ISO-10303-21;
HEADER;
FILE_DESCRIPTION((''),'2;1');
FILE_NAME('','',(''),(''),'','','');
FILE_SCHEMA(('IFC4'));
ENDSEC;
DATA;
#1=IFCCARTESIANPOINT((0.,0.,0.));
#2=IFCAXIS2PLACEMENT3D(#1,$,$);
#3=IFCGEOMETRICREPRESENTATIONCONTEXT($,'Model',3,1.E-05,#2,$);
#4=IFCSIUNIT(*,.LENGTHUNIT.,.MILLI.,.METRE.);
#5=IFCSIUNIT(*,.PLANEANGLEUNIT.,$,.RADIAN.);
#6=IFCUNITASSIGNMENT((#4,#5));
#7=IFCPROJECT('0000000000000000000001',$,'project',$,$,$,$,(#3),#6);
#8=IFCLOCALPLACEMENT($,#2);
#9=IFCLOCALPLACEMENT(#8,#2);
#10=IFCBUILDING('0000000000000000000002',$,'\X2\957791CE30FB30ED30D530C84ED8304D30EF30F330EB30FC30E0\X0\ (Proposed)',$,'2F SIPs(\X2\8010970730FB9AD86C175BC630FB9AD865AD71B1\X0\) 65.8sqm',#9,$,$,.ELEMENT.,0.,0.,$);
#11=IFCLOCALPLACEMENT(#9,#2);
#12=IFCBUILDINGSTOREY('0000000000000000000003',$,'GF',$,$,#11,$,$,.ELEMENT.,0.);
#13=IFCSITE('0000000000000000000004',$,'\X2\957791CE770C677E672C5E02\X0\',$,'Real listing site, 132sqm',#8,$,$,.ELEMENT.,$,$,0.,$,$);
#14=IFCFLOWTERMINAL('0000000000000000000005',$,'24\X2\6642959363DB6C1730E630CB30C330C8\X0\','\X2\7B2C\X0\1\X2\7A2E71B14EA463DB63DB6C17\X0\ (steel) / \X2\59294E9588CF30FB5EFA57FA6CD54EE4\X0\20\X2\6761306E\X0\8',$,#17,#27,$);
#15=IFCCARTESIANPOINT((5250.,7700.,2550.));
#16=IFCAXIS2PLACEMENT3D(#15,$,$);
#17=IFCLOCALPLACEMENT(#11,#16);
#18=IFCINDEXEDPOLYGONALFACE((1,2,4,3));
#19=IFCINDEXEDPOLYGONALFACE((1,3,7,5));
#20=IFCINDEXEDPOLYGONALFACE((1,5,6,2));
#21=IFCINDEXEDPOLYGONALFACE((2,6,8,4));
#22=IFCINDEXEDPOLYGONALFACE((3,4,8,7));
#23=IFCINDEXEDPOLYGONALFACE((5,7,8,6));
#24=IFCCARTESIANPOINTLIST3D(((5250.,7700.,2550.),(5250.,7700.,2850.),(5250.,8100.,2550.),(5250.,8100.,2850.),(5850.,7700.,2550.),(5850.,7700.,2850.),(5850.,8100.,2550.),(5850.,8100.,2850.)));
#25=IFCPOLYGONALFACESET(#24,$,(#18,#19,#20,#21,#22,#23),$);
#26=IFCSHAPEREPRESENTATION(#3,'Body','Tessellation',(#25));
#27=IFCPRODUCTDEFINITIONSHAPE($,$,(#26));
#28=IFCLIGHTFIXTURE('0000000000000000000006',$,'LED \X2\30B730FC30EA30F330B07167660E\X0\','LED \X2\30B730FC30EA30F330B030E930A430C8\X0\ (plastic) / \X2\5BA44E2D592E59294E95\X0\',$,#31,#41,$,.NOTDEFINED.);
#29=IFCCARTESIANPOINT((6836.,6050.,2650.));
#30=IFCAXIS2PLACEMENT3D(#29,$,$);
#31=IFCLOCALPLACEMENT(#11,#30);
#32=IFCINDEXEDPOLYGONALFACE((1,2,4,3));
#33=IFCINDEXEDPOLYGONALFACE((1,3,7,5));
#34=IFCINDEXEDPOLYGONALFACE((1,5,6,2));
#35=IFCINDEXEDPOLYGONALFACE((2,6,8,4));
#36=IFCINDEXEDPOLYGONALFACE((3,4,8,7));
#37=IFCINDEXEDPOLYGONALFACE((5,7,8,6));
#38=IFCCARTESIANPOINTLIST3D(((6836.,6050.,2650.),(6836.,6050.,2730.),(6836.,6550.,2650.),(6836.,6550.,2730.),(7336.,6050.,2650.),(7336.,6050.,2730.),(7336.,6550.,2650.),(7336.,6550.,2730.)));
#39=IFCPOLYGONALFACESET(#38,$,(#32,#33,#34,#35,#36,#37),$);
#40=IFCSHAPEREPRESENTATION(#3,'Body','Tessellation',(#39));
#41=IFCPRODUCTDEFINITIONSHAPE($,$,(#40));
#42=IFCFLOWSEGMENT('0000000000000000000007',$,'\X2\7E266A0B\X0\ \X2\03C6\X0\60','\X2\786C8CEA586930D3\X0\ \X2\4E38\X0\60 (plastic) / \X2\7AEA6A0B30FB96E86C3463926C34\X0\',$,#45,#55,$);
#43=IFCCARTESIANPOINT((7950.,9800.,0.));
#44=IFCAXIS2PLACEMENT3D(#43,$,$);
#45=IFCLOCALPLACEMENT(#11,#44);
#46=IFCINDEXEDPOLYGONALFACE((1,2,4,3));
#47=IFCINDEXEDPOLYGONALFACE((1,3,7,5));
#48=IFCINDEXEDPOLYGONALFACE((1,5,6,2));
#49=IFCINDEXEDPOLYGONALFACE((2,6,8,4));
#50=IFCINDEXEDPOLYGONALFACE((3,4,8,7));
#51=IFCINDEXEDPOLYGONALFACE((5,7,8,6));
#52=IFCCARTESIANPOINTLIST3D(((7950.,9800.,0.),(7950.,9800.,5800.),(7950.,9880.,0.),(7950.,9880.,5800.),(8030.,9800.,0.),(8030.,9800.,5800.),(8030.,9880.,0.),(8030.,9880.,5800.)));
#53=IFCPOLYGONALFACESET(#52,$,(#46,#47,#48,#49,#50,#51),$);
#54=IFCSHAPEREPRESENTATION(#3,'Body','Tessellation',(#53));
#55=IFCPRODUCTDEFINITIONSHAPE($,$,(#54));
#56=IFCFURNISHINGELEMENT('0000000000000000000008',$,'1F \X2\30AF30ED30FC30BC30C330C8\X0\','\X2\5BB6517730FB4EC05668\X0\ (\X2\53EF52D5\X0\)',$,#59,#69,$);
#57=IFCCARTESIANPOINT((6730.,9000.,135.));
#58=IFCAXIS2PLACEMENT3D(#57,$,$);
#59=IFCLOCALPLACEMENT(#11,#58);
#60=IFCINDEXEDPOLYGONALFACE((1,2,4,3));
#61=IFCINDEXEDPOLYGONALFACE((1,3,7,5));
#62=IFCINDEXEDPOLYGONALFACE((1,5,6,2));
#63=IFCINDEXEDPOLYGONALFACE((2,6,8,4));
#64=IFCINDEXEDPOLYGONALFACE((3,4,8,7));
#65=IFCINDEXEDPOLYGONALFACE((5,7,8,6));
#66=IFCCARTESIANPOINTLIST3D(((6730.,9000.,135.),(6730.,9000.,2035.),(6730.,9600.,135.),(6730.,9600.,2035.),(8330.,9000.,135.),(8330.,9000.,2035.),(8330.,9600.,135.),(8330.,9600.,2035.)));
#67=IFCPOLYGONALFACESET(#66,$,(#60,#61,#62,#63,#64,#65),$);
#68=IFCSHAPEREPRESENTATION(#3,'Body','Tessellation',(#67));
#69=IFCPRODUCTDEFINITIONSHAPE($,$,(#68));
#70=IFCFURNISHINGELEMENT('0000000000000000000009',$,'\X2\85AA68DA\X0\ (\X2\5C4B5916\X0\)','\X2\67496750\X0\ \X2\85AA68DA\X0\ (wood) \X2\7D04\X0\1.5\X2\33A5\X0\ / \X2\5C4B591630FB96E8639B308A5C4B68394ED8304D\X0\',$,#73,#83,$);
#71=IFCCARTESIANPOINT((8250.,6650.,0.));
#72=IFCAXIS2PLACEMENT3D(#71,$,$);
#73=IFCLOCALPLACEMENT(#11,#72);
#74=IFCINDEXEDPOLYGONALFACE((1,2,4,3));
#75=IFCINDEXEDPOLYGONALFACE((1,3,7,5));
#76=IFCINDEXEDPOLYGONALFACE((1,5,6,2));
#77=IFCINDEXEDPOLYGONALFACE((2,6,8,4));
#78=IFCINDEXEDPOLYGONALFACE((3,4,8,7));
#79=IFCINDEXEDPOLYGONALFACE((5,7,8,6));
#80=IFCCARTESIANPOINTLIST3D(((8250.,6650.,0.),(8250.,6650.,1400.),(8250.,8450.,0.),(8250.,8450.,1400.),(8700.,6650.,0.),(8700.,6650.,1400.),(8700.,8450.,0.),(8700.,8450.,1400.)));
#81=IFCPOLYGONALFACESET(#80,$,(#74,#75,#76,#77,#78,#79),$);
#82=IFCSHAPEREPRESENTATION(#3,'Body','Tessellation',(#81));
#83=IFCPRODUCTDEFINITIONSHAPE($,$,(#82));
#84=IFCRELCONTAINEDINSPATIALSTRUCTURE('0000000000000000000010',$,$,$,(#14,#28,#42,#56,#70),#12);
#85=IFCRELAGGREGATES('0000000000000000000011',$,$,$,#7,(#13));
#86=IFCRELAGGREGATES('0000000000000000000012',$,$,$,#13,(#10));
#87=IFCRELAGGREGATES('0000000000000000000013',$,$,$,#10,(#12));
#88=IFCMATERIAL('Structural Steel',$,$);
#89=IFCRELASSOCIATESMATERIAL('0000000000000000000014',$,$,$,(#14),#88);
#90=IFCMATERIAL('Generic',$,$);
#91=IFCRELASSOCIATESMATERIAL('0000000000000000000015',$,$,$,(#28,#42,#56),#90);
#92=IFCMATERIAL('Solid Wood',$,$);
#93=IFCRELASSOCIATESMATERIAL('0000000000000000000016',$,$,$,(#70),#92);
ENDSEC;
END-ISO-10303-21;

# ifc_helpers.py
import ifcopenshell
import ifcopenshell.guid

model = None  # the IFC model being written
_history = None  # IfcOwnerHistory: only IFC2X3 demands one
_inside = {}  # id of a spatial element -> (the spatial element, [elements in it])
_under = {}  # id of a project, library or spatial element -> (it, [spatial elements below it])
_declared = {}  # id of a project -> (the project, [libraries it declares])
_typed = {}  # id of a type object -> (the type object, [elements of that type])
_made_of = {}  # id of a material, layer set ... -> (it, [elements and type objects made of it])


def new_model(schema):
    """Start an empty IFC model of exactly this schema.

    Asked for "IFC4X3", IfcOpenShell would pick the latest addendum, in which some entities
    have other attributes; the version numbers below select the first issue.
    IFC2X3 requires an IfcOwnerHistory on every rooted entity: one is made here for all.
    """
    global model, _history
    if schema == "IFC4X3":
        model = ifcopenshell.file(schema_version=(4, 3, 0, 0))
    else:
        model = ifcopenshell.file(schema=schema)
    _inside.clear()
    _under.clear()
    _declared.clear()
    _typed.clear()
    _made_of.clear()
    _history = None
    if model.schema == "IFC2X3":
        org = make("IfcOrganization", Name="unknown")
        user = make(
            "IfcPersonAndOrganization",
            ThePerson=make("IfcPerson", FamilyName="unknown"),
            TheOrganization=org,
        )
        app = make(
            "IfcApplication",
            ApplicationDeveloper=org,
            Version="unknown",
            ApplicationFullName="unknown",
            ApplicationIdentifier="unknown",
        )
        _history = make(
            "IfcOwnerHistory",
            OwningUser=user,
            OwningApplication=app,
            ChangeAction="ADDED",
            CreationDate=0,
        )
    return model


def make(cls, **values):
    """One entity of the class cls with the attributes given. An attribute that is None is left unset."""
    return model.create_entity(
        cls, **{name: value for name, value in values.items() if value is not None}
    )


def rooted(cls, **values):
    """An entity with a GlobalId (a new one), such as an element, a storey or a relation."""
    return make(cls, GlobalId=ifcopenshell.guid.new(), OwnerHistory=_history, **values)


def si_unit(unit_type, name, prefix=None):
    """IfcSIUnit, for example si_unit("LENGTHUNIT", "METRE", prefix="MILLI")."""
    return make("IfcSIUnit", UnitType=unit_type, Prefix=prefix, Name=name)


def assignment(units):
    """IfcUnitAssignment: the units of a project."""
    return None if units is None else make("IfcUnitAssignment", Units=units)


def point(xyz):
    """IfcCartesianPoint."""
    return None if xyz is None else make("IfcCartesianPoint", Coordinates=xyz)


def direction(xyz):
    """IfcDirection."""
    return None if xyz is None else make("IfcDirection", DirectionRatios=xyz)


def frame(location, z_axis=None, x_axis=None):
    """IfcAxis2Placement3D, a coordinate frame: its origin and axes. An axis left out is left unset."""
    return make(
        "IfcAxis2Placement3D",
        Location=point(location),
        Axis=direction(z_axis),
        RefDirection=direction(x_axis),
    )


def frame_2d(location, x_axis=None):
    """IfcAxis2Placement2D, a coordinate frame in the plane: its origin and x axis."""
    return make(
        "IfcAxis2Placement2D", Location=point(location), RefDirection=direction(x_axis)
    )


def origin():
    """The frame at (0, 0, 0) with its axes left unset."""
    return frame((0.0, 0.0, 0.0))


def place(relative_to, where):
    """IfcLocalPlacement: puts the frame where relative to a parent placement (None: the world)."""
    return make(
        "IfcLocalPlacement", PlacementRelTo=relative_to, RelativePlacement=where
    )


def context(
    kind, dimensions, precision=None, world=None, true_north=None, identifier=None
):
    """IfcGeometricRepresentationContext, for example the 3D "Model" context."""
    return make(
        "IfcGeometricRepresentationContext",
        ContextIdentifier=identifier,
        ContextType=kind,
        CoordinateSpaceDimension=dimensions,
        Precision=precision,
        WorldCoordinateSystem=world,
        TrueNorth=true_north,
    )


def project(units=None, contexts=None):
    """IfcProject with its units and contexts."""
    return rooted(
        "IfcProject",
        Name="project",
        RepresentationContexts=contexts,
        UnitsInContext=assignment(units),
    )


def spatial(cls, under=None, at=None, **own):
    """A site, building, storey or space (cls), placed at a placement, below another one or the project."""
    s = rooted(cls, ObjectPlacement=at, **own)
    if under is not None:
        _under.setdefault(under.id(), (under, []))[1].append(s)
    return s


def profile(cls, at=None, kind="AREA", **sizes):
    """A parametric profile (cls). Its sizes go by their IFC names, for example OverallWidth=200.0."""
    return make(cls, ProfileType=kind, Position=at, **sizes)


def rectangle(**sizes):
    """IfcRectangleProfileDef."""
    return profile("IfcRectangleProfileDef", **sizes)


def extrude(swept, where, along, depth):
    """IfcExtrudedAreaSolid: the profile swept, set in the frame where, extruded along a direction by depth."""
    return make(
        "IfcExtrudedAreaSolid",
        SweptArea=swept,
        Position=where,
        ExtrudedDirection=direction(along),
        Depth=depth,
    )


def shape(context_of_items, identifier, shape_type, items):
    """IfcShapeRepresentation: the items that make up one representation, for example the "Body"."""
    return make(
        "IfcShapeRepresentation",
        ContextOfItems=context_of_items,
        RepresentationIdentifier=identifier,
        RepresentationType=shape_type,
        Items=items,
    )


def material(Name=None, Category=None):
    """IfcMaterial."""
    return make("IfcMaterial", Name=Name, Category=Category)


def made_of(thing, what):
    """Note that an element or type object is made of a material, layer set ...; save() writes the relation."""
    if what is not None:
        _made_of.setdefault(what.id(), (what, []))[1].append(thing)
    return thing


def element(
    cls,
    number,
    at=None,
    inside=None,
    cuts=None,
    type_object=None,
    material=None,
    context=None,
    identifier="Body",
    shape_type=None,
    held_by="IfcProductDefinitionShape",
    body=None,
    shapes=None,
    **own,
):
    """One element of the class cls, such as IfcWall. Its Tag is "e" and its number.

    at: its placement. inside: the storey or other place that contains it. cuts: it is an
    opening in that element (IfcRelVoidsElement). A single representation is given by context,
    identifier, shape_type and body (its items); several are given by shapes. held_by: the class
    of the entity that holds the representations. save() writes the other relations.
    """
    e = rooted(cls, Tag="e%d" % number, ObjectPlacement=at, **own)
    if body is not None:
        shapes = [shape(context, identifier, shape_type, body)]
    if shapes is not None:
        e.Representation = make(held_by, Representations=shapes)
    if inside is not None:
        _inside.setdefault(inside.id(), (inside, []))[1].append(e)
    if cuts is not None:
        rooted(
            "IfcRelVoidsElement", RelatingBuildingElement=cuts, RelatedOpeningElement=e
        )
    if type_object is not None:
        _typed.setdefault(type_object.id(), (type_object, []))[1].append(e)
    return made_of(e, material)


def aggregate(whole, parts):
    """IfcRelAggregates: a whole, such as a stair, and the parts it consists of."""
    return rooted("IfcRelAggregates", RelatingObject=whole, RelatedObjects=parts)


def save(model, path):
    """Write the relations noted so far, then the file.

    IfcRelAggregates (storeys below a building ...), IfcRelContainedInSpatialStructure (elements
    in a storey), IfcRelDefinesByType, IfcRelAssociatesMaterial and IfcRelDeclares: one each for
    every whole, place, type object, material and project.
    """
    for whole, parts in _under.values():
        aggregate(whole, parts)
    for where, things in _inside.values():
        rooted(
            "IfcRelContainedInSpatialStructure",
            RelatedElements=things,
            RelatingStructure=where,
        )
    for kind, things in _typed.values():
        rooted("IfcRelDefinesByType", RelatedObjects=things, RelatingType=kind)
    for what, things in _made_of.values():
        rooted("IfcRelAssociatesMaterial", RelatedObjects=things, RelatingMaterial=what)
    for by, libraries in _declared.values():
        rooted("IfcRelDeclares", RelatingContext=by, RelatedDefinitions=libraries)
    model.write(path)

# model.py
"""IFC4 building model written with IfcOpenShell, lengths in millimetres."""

from ifc_helpers import new_model, si_unit, frame, frame_2d, origin, place, context, project, spatial, rectangle, extrude, material, element, save


model = new_model("IFC4")

# Units and contexts
model_context = context("Model", 3, precision=1e-05, world=origin())
ifc_project = project(units=[si_unit("LENGTHUNIT", "METRE", prefix="MILLI"), si_unit("PLANEANGLEUNIT", "RADIAN")], contexts=[model_context])

# Site, building, storey
site_placement = place(None, origin())
site = spatial("IfcSite", under=ifc_project, at=site_placement, Name="長野県松本市", ObjectType="Real listing site, 132sqm", CompositionType="ELEMENT", RefElevation=0.0)
building_placement = place(site_placement, origin())
building = spatial("IfcBuilding", under=site, at=building_placement, Name="長野・ロフト付きワンルーム (Proposed)", ObjectType="2F SIPs(耐震・高気密・高断熱) 65.8sqm", CompositionType="ELEMENT", ElevationOfRefHeight=0.0, ElevationOfTerrain=0.0)
storey_placement = place(building_placement, origin())
storey = spatial("IfcBuildingStorey", under=building, at=storey_placement, Name="GF", CompositionType="ELEMENT", Elevation=0.0)

# Shared definitions
ifc_material_1 = material(Name="Solid Wood")

# Shared definitions
ifc_material_2 = material(Name="Generic")

# Flow terminal
ifc_material_3 = material(Name="Structural Steel")
flow_terminal_placement = place(storey_placement, frame((5250.0, 7700.0, 2550.0)))
element("IfcFlowTerminal", 1, at=flow_terminal_placement, inside=storey, material=ifc_material_3, Name="24時間換気ユニット", Description="第1種熱交換換気 (steel) / 天井裏・建基法令20条の8", context=model_context, shape_type="SweptSolid", body=[
    extrude(rectangle(XDim=600.0, YDim=400.0, at=frame_2d((300.0, 200.0))), frame((5250.0, 7700.0, 2550.0)), (0.0, 0.0, 1.0), 300.0),
])

# Light fixture
light_fixture_placement = place(storey_placement, frame((6836.0, 6050.0, 2650.0)))
element("IfcLightFixture", 2, at=light_fixture_placement, inside=storey, material=ifc_material_2, Name="LED シーリング照明", Description="LED シーリングライト (plastic) / 室中央天井", PredefinedType="NOTDEFINED", context=model_context, shape_type="SweptSolid", body=[
    extrude(rectangle(XDim=500.0, YDim=500.0, at=frame_2d((250.0, 250.0))), frame((6836.0, 6050.0, 2650.0)), (0.0, 0.0, 1.0), 80.0),
])

# Flow segment
flow_segment_placement = place(storey_placement, frame((7950.0, 9800.0, 0.0)))
element("IfcFlowSegment", 3, at=flow_segment_placement, inside=storey, material=ifc_material_2, Name="縦樋 φ60", Description="硬質塩ビ 丸60 (plastic) / 竪樋・雨水排水", context=model_context, shape_type="SweptSolid", body=[
    extrude(rectangle(XDim=80.0, YDim=80.0, at=frame_2d((40.0, 40.0))), frame((7950.0, 9800.0, 0.0)), (0.0, 0.0, 1.0), 5800.0),
])

# Furnishing elements
furnishing_1_placement = place(storey_placement, frame((6730.0, 9000.0, 135.0)))
element("IfcFurnishingElement", 4, at=furnishing_1_placement, inside=storey, material=ifc_material_2, Name="1F クローゼット", Description="家具・什器 (可動)", context=model_context, shape_type="SweptSolid", body=[
    extrude(rectangle(XDim=1600.0, YDim=600.0, at=frame_2d((800.0, 300.0))), frame((6730.0, 9000.0, 135.0)), (0.0, 0.0, 1.0), 1900.0),
])
furnishing_2_placement = place(storey_placement, frame((8250.0, 6650.0, 0.0)))
element("IfcFurnishingElement", 5, at=furnishing_2_placement, inside=storey, material=ifc_material_1, Name="薪棚 (屋外)", Description="杉材 薪棚 (wood) 約1.5㎥ / 屋外・雨掛り屋根付き", context=model_context, shape_type="SweptSolid", body=[
    extrude(rectangle(XDim=450.0, YDim=1800.0, at=frame_2d((225.0, 900.0))), frame((8250.0, 6650.0, 0.0)), (0.0, 0.0, 1.0), 1400.0),
])

save(model, "model.ifc")
